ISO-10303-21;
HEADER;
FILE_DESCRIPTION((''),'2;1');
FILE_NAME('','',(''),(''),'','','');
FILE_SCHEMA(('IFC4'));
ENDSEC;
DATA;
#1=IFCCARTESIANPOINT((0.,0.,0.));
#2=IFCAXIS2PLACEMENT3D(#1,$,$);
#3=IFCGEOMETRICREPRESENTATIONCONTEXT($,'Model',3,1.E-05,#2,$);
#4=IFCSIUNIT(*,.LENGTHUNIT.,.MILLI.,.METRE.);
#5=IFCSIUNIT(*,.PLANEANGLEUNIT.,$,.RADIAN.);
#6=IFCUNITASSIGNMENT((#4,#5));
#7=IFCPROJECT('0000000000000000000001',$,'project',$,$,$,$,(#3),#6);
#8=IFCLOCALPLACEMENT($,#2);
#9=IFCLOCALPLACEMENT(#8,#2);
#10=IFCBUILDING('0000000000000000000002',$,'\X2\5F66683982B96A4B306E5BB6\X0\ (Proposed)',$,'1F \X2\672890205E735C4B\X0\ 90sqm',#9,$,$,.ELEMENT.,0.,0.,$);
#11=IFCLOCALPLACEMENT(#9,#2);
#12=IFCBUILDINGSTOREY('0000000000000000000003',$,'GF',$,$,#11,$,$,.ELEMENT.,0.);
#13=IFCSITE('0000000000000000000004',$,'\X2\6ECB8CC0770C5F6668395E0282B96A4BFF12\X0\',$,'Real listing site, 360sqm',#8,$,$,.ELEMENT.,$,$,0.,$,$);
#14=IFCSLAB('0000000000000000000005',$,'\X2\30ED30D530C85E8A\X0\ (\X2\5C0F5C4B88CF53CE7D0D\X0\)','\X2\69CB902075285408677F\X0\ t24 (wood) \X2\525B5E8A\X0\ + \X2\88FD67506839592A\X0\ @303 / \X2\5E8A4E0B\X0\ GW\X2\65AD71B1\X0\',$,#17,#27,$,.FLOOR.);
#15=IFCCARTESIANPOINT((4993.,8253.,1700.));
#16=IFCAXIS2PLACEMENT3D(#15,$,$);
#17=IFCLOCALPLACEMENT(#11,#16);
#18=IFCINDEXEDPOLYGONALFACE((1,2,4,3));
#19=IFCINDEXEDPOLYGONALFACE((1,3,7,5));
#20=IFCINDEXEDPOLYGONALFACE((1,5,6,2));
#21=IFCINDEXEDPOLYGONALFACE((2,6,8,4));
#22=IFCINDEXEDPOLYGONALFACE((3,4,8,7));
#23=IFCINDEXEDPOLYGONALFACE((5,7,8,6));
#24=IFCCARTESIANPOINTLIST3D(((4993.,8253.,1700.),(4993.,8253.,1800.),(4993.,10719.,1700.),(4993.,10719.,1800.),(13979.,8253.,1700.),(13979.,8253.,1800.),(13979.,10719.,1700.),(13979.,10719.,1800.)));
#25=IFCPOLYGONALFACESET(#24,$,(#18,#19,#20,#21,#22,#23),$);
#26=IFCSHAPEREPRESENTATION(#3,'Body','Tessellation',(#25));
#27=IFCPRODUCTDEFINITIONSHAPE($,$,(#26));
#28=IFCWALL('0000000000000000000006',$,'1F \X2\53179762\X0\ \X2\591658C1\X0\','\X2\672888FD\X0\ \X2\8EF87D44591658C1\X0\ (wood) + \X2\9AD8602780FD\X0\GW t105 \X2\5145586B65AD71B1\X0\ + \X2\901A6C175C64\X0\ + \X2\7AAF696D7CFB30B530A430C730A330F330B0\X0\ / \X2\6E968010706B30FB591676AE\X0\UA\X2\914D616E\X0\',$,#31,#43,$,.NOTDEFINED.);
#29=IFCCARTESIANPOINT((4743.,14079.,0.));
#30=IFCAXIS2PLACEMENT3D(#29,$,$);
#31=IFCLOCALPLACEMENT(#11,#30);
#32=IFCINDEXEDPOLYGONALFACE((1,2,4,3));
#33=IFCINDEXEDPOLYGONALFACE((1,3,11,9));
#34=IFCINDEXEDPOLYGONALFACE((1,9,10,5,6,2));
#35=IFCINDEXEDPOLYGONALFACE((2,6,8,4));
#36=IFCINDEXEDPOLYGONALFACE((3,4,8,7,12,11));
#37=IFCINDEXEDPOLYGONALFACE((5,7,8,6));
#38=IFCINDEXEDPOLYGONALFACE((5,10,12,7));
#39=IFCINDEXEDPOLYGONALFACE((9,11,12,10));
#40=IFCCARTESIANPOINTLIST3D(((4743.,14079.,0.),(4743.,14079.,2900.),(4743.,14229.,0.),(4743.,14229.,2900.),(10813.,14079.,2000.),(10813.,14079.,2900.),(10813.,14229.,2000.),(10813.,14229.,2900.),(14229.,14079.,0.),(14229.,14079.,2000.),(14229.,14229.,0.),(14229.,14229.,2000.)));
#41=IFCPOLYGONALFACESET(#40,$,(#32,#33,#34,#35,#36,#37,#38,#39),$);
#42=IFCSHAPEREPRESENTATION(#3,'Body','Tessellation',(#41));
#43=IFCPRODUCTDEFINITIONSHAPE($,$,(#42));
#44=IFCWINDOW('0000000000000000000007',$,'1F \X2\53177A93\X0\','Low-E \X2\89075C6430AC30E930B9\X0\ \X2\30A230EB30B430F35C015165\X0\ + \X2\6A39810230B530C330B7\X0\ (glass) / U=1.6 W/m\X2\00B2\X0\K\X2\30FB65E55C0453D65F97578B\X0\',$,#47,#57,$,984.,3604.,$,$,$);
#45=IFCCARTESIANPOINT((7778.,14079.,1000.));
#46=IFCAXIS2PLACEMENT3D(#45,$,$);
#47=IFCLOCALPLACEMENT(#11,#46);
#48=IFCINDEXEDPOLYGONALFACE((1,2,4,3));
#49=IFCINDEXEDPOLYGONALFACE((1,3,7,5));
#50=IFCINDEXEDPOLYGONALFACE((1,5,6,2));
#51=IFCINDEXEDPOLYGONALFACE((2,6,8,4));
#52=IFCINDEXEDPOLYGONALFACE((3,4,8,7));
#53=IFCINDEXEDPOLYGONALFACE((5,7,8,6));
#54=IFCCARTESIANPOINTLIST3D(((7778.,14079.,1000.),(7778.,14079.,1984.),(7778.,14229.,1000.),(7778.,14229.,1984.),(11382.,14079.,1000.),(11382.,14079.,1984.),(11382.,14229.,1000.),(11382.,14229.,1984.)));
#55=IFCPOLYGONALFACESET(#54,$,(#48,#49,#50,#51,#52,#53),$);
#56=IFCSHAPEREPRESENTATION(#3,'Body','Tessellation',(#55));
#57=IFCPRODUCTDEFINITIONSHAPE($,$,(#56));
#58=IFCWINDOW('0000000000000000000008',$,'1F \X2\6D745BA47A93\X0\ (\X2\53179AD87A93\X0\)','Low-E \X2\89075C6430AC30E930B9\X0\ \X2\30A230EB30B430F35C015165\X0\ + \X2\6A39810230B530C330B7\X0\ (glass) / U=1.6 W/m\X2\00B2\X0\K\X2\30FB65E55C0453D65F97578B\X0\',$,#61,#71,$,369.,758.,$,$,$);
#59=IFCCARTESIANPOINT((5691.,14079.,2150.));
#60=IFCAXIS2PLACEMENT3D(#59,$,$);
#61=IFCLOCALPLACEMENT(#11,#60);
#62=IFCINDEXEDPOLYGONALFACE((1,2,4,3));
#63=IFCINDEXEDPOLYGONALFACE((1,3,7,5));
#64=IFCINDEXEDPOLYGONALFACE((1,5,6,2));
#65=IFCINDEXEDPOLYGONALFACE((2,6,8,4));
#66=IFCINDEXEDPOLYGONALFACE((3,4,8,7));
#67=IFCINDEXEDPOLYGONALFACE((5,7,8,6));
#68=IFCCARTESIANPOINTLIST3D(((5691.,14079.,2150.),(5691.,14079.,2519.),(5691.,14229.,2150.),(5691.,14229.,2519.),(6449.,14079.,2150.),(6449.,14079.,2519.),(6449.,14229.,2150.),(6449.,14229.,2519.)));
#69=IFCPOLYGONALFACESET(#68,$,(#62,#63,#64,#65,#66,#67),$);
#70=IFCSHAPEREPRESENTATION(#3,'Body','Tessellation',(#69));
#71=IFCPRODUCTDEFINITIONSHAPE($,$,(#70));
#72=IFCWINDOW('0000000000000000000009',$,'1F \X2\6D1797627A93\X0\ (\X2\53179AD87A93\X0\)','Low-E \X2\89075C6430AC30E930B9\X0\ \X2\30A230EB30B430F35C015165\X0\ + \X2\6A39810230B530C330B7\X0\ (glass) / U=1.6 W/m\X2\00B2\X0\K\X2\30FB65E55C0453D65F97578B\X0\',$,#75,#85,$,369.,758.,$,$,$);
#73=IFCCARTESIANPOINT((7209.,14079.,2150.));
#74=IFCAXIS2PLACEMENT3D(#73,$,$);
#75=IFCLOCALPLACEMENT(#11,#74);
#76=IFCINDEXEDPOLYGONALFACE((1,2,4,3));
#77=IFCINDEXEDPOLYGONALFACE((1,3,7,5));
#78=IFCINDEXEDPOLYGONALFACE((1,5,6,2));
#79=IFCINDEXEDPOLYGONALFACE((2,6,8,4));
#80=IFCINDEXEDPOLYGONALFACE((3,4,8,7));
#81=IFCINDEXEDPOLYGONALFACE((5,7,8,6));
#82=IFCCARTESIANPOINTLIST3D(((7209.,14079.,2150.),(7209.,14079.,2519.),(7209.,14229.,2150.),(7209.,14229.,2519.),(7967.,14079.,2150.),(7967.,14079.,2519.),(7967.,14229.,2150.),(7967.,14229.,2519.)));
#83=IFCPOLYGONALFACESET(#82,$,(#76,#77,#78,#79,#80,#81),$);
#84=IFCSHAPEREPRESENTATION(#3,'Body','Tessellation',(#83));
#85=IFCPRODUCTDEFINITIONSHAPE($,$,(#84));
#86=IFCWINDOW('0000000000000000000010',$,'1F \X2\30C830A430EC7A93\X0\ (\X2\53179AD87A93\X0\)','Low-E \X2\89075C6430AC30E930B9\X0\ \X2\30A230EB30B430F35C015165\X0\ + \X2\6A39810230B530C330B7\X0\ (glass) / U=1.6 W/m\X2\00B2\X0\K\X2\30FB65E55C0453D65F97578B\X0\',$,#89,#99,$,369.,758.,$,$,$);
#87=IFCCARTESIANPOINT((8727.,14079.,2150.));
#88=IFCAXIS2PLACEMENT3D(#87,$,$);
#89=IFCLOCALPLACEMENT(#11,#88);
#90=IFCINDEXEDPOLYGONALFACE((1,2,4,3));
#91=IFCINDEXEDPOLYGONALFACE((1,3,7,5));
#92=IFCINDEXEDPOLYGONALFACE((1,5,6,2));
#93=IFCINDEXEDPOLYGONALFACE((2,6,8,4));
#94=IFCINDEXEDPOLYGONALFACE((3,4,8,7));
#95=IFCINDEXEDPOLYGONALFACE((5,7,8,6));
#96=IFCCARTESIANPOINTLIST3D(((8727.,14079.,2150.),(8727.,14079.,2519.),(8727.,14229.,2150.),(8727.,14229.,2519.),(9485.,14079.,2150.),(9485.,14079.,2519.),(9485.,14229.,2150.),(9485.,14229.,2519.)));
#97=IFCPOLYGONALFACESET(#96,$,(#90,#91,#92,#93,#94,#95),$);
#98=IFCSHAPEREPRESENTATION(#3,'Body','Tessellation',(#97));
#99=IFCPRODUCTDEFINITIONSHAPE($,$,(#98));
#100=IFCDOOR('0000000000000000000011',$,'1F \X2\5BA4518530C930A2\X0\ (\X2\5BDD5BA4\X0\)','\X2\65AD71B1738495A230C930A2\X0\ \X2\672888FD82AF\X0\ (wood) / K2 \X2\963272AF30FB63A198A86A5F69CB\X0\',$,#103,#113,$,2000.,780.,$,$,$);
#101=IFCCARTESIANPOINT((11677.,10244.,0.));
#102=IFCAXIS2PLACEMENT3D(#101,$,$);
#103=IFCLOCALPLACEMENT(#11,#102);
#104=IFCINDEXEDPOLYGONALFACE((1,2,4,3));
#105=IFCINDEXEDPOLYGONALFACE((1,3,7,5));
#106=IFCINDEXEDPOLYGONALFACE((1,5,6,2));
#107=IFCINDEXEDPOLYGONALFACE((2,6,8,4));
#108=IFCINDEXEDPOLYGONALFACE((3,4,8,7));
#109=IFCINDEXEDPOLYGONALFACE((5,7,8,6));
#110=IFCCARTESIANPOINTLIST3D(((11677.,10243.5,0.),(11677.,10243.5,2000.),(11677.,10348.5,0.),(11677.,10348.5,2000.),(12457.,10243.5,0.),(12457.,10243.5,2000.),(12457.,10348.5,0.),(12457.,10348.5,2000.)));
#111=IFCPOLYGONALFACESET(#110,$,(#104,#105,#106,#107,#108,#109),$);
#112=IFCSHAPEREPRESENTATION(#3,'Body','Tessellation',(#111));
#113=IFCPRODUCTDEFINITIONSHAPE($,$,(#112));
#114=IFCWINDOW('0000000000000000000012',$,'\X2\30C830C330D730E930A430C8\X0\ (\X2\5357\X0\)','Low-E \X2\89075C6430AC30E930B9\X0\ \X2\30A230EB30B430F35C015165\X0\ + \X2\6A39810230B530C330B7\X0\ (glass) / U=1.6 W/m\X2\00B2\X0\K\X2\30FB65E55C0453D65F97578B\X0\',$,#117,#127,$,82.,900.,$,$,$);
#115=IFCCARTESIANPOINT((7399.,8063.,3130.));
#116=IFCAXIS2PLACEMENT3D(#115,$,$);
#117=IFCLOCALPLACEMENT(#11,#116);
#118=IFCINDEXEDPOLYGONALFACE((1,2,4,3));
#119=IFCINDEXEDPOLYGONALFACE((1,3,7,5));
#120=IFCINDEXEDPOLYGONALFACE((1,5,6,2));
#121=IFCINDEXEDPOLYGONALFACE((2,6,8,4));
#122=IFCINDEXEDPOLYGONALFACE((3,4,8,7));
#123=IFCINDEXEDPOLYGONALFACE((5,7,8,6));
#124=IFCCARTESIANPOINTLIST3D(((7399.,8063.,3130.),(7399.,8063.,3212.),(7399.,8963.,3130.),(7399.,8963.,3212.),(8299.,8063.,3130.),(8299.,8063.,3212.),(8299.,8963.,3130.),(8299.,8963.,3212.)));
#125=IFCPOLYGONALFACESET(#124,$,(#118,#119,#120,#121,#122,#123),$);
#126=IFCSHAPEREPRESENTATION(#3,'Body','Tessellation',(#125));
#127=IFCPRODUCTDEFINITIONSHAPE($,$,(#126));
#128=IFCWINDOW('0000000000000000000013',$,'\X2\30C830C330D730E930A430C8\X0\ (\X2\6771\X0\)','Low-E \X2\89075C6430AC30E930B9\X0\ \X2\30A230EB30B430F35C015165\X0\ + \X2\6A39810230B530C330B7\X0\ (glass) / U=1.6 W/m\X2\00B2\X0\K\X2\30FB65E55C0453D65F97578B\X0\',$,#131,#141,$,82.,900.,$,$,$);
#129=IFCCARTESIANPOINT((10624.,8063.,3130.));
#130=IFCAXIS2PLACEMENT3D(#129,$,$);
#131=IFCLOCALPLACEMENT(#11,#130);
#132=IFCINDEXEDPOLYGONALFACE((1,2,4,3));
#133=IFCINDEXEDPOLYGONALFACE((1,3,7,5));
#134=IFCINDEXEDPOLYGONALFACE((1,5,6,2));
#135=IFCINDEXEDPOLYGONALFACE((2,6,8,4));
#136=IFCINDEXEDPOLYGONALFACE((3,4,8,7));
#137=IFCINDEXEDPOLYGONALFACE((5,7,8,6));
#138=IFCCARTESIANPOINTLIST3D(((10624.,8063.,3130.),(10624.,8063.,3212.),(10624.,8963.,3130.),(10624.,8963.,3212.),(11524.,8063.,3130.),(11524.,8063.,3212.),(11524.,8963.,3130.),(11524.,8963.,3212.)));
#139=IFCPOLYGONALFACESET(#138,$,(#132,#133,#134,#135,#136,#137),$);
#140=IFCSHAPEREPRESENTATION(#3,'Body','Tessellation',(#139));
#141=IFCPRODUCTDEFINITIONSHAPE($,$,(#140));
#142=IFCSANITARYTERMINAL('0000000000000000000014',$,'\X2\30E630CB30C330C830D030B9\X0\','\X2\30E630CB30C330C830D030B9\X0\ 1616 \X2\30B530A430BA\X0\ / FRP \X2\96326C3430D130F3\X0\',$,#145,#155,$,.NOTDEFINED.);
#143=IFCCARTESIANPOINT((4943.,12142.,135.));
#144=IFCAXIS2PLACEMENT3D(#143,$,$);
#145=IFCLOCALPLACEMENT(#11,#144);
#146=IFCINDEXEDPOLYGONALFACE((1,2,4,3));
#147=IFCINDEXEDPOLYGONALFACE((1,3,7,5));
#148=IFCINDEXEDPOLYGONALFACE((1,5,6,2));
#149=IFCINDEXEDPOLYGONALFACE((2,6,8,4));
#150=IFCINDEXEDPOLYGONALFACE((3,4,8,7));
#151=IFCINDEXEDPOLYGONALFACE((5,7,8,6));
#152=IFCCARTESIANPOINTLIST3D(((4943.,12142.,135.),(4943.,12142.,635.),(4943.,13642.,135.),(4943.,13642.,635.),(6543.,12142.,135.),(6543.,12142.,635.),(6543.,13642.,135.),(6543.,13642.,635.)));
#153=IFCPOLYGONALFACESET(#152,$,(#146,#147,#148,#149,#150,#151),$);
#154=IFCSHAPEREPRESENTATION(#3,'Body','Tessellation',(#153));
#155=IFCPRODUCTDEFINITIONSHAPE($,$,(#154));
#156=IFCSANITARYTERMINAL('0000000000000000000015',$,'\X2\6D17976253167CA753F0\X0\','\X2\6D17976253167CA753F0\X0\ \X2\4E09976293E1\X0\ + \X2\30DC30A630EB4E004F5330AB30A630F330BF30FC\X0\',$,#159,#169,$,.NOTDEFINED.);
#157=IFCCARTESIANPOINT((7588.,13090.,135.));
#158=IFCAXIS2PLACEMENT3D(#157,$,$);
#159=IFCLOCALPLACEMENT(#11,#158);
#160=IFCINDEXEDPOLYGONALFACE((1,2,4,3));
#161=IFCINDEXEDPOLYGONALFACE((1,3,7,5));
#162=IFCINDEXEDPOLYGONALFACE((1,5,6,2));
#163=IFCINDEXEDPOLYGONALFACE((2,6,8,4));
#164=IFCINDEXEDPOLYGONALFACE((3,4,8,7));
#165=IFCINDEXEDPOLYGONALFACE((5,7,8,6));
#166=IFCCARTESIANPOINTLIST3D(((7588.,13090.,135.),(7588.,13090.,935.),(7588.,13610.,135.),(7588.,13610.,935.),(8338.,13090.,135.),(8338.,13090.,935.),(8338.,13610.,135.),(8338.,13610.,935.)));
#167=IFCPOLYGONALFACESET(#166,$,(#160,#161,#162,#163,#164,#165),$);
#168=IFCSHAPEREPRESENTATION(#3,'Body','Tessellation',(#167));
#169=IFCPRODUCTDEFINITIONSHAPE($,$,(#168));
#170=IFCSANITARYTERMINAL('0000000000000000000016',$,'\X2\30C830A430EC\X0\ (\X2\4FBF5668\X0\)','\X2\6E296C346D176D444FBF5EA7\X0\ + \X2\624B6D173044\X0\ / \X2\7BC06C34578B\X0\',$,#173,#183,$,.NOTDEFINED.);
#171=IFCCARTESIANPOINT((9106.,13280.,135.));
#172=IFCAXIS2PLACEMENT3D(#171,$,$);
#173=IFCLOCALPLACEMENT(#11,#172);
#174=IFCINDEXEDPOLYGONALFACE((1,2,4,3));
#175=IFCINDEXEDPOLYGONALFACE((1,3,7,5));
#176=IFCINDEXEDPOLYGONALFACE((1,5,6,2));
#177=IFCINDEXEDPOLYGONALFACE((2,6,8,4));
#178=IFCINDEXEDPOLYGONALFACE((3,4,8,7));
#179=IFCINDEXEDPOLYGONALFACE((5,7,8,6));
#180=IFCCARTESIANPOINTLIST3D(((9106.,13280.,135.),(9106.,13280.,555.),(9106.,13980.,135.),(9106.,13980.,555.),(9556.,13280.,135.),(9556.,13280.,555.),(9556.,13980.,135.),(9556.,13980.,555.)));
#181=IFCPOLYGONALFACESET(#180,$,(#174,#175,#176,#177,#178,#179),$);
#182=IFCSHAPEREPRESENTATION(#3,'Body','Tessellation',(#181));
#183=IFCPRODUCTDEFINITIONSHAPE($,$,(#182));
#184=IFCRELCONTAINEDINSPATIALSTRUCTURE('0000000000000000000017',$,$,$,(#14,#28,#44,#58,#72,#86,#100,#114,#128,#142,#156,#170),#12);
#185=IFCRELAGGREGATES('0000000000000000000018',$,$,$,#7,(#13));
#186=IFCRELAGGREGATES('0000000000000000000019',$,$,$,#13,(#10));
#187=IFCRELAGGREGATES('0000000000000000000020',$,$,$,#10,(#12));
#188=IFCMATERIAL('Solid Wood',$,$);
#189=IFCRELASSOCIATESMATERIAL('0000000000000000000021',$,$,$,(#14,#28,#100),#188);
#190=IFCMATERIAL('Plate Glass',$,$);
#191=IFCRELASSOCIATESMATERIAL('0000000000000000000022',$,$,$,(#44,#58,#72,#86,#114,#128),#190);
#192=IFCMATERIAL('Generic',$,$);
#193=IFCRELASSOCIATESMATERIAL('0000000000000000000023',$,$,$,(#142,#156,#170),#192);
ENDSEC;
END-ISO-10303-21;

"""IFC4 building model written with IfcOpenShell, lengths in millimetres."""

from ifc_helpers import new_model, si_unit, frame, frame_2d, origin, place, context, project, spatial, rectangle, extrude, material, element, fill, save


model = new_model("IFC4")

# Units and contexts
model_context = context("Model", 3, precision=1e-05, world=origin())
ifc_project = project(units=[si_unit("LENGTHUNIT", "METRE", prefix="MILLI"), si_unit("PLANEANGLEUNIT", "RADIAN")], contexts=[model_context])

# Site, building, storey
site_placement = place(None, origin())
site = spatial("IfcSite", under=ifc_project, at=site_placement, Name="滋賀県彦根市芹橋２", ObjectType="Real listing site, 360sqm", CompositionType="ELEMENT", RefElevation=0.0)
building_placement = place(site_placement, origin())
building = spatial("IfcBuilding", under=site, at=building_placement, Name="彦根芹橋の家 (Proposed)", ObjectType="1F 木造平屋 90sqm", CompositionType="ELEMENT", ElevationOfRefHeight=0.0, ElevationOfTerrain=0.0)
storey_placement = place(building_placement, origin())
storey = spatial("IfcBuildingStorey", under=building, at=storey_placement, Name="GF", CompositionType="ELEMENT", Elevation=0.0)

# Slab
ifc_material_1 = material(Name="Solid Wood")
slab_placement = place(storey_placement, frame((4993.0, 8253.0, 1700.0)))
element("IfcSlab", 1, at=slab_placement, inside=storey, material=ifc_material_1, Name="ロフト床 (小屋裏収納)", Description="構造用合板 t24 (wood) 剛床 + 製材根太 @303 / 床下 GW断熱", PredefinedType="FLOOR", context=model_context, shape_type="SweptSolid", body=[
    extrude(rectangle(XDim=8986.0, YDim=2466.0, at=frame_2d((4493.0, 1233.0))), frame((4993.0, 8253.0, 1700.0)), (0.0, 0.0, 1.0), 100.0),
])

# Wall, openings, windows
wall_1_placement = place(storey_placement, frame((4743.0, 14079.0, 0.0)))
wall_1 = element("IfcWall", 2, at=wall_1_placement, inside=storey, material=ifc_material_1, Name="1F 北面 外壁", Description="木製 軸組外壁 (wood) + 高性能GW t105 充填断熱 + 通気層 + 窯業系サイディング / 準耐火・外皮UA配慮", PredefinedType="NOTDEFINED", context=model_context, shape_type="SweptSolid", body=[
    extrude(rectangle(XDim=9486.0, YDim=150.0, at=frame_2d((4743.0, 75.0))), frame((4743.0, 14079.0, 0.0)), (0.0, 0.0, 1.0), 2900.0),
])
opening_1_placement = place(storey_placement, frame((7778.0, 14079.0, 1000.0)))
opening_1 = element("IfcOpeningElement", 3, at=opening_1_placement, cuts=wall_1, PredefinedType="NOTDEFINED", context=model_context, shape_type="SweptSolid", body=[
    extrude(rectangle(XDim=3604.0, YDim=150.0, at=frame_2d((1802.0, 75.0))), frame((7778.0, 14079.0, 1000.0)), (0.0, 0.0, 1.0), 984.0),
])
opening_2_placement = place(storey_placement, frame((5691.0, 14079.0, 2150.0)))
opening_2 = element("IfcOpeningElement", 4, at=opening_2_placement, cuts=wall_1, PredefinedType="NOTDEFINED", context=model_context, shape_type="SweptSolid", body=[
    extrude(rectangle(XDim=758.0, YDim=150.0, at=frame_2d((379.0, 75.0))), frame((5691.0, 14079.0, 2150.0)), (0.0, 0.0, 1.0), 369.0),
])
opening_3_placement = place(storey_placement, frame((7209.0, 14079.0, 2150.0)))
opening_3 = element("IfcOpeningElement", 5, at=opening_3_placement, cuts=wall_1, PredefinedType="NOTDEFINED", context=model_context, shape_type="SweptSolid", body=[
    extrude(rectangle(XDim=758.0, YDim=150.0, at=frame_2d((379.0, 75.0))), frame((7209.0, 14079.0, 2150.0)), (0.0, 0.0, 1.0), 369.0),
])
opening_4_placement = place(storey_placement, frame((8727.0, 14079.0, 2150.0)))
opening_4 = element("IfcOpeningElement", 6, at=opening_4_placement, cuts=wall_1, PredefinedType="NOTDEFINED", context=model_context, shape_type="SweptSolid", body=[
    extrude(rectangle(XDim=758.0, YDim=150.0, at=frame_2d((379.0, 75.0))), frame((8727.0, 14079.0, 2150.0)), (0.0, 0.0, 1.0), 369.0),
])
ifc_material_2 = material(Name="Plate Glass")
window_1_placement = place(storey_placement, frame((7778.0, 14079.0, 1000.0)))
window_1 = element("IfcWindow", 7, at=window_1_placement, inside=storey, material=ifc_material_2, Name="1F 北窓", Description="Low-E 複層ガラス アルゴン封入 + 樹脂サッシ (glass) / U=1.6 W/m²K・日射取得型", OverallHeight=984.0, OverallWidth=3604.0, context=model_context, shape_type="SweptSolid", body=[
    extrude(rectangle(XDim=3604.0, YDim=150.0, at=frame_2d((1802.0, 75.0))), frame((7778.0, 14079.0, 1000.0)), (0.0, 0.0, 1.0), 984.0),
])
fill(opening_1, window_1)
window_2_placement = place(storey_placement, frame((5691.0, 14079.0, 2150.0)))
window_2 = element("IfcWindow", 8, at=window_2_placement, inside=storey, material=ifc_material_2, Name="1F 浴室窓 (北高窓)", Description="Low-E 複層ガラス アルゴン封入 + 樹脂サッシ (glass) / U=1.6 W/m²K・日射取得型", OverallHeight=369.0, OverallWidth=758.0, context=model_context, shape_type="SweptSolid", body=[
    extrude(rectangle(XDim=758.0, YDim=150.0, at=frame_2d((379.0, 75.0))), frame((5691.0, 14079.0, 2150.0)), (0.0, 0.0, 1.0), 369.0),
])
fill(opening_2, window_2)
window_3_placement = place(storey_placement, frame((7209.0, 14079.0, 2150.0)))
window_3 = element("IfcWindow", 9, at=window_3_placement, inside=storey, material=ifc_material_2, Name="1F 洗面窓 (北高窓)", Description="Low-E 複層ガラス アルゴン封入 + 樹脂サッシ (glass) / U=1.6 W/m²K・日射取得型", OverallHeight=369.0, OverallWidth=758.0, context=model_context, shape_type="SweptSolid", body=[
    extrude(rectangle(XDim=758.0, YDim=150.0, at=frame_2d((379.0, 75.0))), frame((7209.0, 14079.0, 2150.0)), (0.0, 0.0, 1.0), 369.0),
])
fill(opening_3, window_3)
window_4_placement = place(storey_placement, frame((8727.0, 14079.0, 2150.0)))
window_4 = element("IfcWindow", 10, at=window_4_placement, inside=storey, material=ifc_material_2, Name="1F トイレ窓 (北高窓)", Description="Low-E 複層ガラス アルゴン封入 + 樹脂サッシ (glass) / U=1.6 W/m²K・日射取得型", OverallHeight=369.0, OverallWidth=758.0, context=model_context, shape_type="SweptSolid", body=[
    extrude(rectangle(XDim=758.0, YDim=150.0, at=frame_2d((379.0, 75.0))), frame((8727.0, 14079.0, 2150.0)), (0.0, 0.0, 1.0), 369.0),
])
fill(opening_4, window_4)

# Door
door_1_placement = place(storey_placement, frame((11677.0, 10244.0, 0.0)))
element("IfcDoor", 11, at=door_1_placement, inside=storey, material=ifc_material_1, Name="1F 室内ドア (寝室)", Description="断熱玄関ドア 木製芯 (wood) / K2 防犯・採風機構", OverallHeight=2000.0, OverallWidth=780.0, context=model_context, shape_type="SweptSolid", body=[
    extrude(rectangle(XDim=780.0, YDim=105.0, at=frame_2d((390.0, 52.0))), frame((11677.0, 10244.0, 0.0)), (0.0, 0.0, 1.0), 2000.0),
])

# Windows
window_5_placement = place(storey_placement, frame((7399.0, 8063.0, 3130.0)))
element("IfcWindow", 12, at=window_5_placement, inside=storey, material=ifc_material_2, Name="トップライト (南)", Description="Low-E 複層ガラス アルゴン封入 + 樹脂サッシ (glass) / U=1.6 W/m²K・日射取得型", OverallHeight=82.0, OverallWidth=900.0, context=model_context, shape_type="SweptSolid", body=[
    extrude(rectangle(XDim=900.0, YDim=900.0, at=frame_2d((450.0, 450.0))), frame((7399.0, 8063.0, 3130.0)), (0.0, 0.0, 1.0), 82.0),
])
window_6_placement = place(storey_placement, frame((10624.0, 8063.0, 3130.0)))
element("IfcWindow", 13, at=window_6_placement, inside=storey, material=ifc_material_2, Name="トップライト (東)", Description="Low-E 複層ガラス アルゴン封入 + 樹脂サッシ (glass) / U=1.6 W/m²K・日射取得型", OverallHeight=82.0, OverallWidth=900.0, context=model_context, shape_type="SweptSolid", body=[
    extrude(rectangle(XDim=900.0, YDim=900.0, at=frame_2d((450.0, 450.0))), frame((10624.0, 8063.0, 3130.0)), (0.0, 0.0, 1.0), 82.0),
])

# Sanitary terminals
ifc_material_3 = material(Name="Generic")
sanitary_terminal_1_placement = place(storey_placement, frame((4943.0, 12142.0, 135.0)))
element("IfcSanitaryTerminal", 14, at=sanitary_terminal_1_placement, inside=storey, material=ifc_material_3, Name="ユニットバス", Description="ユニットバス 1616 サイズ / FRP 防水パン", PredefinedType="NOTDEFINED", context=model_context, shape_type="SweptSolid", body=[
    extrude(rectangle(XDim=1600.0, YDim=1500.0, at=frame_2d((800.0, 750.0))), frame((4943.0, 12142.0, 135.0)), (0.0, 0.0, 1.0), 500.0),
])
sanitary_terminal_2_placement = place(storey_placement, frame((7588.0, 13090.0, 135.0)))
element("IfcSanitaryTerminal", 15, at=sanitary_terminal_2_placement, inside=storey, material=ifc_material_3, Name="洗面化粧台", Description="洗面化粧台 三面鏡 + ボウル一体カウンター", PredefinedType="NOTDEFINED", context=model_context, shape_type="SweptSolid", body=[
    extrude(rectangle(XDim=750.0, YDim=520.0, at=frame_2d((375.0, 260.0))), frame((7588.0, 13090.0, 135.0)), (0.0, 0.0, 1.0), 800.0),
])
sanitary_terminal_3_placement = place(storey_placement, frame((9106.0, 13280.0, 135.0)))
element("IfcSanitaryTerminal", 16, at=sanitary_terminal_3_placement, inside=storey, material=ifc_material_3, Name="トイレ (便器)", Description="温水洗浄便座 + 手洗い / 節水型", PredefinedType="NOTDEFINED", context=model_context, shape_type="SweptSolid", body=[
    extrude(rectangle(XDim=450.0, YDim=700.0, at=frame_2d((225.0, 350.0))), frame((9106.0, 13280.0, 135.0)), (0.0, 0.0, 1.0), 420.0),
])

save(model, "model.ifc")
